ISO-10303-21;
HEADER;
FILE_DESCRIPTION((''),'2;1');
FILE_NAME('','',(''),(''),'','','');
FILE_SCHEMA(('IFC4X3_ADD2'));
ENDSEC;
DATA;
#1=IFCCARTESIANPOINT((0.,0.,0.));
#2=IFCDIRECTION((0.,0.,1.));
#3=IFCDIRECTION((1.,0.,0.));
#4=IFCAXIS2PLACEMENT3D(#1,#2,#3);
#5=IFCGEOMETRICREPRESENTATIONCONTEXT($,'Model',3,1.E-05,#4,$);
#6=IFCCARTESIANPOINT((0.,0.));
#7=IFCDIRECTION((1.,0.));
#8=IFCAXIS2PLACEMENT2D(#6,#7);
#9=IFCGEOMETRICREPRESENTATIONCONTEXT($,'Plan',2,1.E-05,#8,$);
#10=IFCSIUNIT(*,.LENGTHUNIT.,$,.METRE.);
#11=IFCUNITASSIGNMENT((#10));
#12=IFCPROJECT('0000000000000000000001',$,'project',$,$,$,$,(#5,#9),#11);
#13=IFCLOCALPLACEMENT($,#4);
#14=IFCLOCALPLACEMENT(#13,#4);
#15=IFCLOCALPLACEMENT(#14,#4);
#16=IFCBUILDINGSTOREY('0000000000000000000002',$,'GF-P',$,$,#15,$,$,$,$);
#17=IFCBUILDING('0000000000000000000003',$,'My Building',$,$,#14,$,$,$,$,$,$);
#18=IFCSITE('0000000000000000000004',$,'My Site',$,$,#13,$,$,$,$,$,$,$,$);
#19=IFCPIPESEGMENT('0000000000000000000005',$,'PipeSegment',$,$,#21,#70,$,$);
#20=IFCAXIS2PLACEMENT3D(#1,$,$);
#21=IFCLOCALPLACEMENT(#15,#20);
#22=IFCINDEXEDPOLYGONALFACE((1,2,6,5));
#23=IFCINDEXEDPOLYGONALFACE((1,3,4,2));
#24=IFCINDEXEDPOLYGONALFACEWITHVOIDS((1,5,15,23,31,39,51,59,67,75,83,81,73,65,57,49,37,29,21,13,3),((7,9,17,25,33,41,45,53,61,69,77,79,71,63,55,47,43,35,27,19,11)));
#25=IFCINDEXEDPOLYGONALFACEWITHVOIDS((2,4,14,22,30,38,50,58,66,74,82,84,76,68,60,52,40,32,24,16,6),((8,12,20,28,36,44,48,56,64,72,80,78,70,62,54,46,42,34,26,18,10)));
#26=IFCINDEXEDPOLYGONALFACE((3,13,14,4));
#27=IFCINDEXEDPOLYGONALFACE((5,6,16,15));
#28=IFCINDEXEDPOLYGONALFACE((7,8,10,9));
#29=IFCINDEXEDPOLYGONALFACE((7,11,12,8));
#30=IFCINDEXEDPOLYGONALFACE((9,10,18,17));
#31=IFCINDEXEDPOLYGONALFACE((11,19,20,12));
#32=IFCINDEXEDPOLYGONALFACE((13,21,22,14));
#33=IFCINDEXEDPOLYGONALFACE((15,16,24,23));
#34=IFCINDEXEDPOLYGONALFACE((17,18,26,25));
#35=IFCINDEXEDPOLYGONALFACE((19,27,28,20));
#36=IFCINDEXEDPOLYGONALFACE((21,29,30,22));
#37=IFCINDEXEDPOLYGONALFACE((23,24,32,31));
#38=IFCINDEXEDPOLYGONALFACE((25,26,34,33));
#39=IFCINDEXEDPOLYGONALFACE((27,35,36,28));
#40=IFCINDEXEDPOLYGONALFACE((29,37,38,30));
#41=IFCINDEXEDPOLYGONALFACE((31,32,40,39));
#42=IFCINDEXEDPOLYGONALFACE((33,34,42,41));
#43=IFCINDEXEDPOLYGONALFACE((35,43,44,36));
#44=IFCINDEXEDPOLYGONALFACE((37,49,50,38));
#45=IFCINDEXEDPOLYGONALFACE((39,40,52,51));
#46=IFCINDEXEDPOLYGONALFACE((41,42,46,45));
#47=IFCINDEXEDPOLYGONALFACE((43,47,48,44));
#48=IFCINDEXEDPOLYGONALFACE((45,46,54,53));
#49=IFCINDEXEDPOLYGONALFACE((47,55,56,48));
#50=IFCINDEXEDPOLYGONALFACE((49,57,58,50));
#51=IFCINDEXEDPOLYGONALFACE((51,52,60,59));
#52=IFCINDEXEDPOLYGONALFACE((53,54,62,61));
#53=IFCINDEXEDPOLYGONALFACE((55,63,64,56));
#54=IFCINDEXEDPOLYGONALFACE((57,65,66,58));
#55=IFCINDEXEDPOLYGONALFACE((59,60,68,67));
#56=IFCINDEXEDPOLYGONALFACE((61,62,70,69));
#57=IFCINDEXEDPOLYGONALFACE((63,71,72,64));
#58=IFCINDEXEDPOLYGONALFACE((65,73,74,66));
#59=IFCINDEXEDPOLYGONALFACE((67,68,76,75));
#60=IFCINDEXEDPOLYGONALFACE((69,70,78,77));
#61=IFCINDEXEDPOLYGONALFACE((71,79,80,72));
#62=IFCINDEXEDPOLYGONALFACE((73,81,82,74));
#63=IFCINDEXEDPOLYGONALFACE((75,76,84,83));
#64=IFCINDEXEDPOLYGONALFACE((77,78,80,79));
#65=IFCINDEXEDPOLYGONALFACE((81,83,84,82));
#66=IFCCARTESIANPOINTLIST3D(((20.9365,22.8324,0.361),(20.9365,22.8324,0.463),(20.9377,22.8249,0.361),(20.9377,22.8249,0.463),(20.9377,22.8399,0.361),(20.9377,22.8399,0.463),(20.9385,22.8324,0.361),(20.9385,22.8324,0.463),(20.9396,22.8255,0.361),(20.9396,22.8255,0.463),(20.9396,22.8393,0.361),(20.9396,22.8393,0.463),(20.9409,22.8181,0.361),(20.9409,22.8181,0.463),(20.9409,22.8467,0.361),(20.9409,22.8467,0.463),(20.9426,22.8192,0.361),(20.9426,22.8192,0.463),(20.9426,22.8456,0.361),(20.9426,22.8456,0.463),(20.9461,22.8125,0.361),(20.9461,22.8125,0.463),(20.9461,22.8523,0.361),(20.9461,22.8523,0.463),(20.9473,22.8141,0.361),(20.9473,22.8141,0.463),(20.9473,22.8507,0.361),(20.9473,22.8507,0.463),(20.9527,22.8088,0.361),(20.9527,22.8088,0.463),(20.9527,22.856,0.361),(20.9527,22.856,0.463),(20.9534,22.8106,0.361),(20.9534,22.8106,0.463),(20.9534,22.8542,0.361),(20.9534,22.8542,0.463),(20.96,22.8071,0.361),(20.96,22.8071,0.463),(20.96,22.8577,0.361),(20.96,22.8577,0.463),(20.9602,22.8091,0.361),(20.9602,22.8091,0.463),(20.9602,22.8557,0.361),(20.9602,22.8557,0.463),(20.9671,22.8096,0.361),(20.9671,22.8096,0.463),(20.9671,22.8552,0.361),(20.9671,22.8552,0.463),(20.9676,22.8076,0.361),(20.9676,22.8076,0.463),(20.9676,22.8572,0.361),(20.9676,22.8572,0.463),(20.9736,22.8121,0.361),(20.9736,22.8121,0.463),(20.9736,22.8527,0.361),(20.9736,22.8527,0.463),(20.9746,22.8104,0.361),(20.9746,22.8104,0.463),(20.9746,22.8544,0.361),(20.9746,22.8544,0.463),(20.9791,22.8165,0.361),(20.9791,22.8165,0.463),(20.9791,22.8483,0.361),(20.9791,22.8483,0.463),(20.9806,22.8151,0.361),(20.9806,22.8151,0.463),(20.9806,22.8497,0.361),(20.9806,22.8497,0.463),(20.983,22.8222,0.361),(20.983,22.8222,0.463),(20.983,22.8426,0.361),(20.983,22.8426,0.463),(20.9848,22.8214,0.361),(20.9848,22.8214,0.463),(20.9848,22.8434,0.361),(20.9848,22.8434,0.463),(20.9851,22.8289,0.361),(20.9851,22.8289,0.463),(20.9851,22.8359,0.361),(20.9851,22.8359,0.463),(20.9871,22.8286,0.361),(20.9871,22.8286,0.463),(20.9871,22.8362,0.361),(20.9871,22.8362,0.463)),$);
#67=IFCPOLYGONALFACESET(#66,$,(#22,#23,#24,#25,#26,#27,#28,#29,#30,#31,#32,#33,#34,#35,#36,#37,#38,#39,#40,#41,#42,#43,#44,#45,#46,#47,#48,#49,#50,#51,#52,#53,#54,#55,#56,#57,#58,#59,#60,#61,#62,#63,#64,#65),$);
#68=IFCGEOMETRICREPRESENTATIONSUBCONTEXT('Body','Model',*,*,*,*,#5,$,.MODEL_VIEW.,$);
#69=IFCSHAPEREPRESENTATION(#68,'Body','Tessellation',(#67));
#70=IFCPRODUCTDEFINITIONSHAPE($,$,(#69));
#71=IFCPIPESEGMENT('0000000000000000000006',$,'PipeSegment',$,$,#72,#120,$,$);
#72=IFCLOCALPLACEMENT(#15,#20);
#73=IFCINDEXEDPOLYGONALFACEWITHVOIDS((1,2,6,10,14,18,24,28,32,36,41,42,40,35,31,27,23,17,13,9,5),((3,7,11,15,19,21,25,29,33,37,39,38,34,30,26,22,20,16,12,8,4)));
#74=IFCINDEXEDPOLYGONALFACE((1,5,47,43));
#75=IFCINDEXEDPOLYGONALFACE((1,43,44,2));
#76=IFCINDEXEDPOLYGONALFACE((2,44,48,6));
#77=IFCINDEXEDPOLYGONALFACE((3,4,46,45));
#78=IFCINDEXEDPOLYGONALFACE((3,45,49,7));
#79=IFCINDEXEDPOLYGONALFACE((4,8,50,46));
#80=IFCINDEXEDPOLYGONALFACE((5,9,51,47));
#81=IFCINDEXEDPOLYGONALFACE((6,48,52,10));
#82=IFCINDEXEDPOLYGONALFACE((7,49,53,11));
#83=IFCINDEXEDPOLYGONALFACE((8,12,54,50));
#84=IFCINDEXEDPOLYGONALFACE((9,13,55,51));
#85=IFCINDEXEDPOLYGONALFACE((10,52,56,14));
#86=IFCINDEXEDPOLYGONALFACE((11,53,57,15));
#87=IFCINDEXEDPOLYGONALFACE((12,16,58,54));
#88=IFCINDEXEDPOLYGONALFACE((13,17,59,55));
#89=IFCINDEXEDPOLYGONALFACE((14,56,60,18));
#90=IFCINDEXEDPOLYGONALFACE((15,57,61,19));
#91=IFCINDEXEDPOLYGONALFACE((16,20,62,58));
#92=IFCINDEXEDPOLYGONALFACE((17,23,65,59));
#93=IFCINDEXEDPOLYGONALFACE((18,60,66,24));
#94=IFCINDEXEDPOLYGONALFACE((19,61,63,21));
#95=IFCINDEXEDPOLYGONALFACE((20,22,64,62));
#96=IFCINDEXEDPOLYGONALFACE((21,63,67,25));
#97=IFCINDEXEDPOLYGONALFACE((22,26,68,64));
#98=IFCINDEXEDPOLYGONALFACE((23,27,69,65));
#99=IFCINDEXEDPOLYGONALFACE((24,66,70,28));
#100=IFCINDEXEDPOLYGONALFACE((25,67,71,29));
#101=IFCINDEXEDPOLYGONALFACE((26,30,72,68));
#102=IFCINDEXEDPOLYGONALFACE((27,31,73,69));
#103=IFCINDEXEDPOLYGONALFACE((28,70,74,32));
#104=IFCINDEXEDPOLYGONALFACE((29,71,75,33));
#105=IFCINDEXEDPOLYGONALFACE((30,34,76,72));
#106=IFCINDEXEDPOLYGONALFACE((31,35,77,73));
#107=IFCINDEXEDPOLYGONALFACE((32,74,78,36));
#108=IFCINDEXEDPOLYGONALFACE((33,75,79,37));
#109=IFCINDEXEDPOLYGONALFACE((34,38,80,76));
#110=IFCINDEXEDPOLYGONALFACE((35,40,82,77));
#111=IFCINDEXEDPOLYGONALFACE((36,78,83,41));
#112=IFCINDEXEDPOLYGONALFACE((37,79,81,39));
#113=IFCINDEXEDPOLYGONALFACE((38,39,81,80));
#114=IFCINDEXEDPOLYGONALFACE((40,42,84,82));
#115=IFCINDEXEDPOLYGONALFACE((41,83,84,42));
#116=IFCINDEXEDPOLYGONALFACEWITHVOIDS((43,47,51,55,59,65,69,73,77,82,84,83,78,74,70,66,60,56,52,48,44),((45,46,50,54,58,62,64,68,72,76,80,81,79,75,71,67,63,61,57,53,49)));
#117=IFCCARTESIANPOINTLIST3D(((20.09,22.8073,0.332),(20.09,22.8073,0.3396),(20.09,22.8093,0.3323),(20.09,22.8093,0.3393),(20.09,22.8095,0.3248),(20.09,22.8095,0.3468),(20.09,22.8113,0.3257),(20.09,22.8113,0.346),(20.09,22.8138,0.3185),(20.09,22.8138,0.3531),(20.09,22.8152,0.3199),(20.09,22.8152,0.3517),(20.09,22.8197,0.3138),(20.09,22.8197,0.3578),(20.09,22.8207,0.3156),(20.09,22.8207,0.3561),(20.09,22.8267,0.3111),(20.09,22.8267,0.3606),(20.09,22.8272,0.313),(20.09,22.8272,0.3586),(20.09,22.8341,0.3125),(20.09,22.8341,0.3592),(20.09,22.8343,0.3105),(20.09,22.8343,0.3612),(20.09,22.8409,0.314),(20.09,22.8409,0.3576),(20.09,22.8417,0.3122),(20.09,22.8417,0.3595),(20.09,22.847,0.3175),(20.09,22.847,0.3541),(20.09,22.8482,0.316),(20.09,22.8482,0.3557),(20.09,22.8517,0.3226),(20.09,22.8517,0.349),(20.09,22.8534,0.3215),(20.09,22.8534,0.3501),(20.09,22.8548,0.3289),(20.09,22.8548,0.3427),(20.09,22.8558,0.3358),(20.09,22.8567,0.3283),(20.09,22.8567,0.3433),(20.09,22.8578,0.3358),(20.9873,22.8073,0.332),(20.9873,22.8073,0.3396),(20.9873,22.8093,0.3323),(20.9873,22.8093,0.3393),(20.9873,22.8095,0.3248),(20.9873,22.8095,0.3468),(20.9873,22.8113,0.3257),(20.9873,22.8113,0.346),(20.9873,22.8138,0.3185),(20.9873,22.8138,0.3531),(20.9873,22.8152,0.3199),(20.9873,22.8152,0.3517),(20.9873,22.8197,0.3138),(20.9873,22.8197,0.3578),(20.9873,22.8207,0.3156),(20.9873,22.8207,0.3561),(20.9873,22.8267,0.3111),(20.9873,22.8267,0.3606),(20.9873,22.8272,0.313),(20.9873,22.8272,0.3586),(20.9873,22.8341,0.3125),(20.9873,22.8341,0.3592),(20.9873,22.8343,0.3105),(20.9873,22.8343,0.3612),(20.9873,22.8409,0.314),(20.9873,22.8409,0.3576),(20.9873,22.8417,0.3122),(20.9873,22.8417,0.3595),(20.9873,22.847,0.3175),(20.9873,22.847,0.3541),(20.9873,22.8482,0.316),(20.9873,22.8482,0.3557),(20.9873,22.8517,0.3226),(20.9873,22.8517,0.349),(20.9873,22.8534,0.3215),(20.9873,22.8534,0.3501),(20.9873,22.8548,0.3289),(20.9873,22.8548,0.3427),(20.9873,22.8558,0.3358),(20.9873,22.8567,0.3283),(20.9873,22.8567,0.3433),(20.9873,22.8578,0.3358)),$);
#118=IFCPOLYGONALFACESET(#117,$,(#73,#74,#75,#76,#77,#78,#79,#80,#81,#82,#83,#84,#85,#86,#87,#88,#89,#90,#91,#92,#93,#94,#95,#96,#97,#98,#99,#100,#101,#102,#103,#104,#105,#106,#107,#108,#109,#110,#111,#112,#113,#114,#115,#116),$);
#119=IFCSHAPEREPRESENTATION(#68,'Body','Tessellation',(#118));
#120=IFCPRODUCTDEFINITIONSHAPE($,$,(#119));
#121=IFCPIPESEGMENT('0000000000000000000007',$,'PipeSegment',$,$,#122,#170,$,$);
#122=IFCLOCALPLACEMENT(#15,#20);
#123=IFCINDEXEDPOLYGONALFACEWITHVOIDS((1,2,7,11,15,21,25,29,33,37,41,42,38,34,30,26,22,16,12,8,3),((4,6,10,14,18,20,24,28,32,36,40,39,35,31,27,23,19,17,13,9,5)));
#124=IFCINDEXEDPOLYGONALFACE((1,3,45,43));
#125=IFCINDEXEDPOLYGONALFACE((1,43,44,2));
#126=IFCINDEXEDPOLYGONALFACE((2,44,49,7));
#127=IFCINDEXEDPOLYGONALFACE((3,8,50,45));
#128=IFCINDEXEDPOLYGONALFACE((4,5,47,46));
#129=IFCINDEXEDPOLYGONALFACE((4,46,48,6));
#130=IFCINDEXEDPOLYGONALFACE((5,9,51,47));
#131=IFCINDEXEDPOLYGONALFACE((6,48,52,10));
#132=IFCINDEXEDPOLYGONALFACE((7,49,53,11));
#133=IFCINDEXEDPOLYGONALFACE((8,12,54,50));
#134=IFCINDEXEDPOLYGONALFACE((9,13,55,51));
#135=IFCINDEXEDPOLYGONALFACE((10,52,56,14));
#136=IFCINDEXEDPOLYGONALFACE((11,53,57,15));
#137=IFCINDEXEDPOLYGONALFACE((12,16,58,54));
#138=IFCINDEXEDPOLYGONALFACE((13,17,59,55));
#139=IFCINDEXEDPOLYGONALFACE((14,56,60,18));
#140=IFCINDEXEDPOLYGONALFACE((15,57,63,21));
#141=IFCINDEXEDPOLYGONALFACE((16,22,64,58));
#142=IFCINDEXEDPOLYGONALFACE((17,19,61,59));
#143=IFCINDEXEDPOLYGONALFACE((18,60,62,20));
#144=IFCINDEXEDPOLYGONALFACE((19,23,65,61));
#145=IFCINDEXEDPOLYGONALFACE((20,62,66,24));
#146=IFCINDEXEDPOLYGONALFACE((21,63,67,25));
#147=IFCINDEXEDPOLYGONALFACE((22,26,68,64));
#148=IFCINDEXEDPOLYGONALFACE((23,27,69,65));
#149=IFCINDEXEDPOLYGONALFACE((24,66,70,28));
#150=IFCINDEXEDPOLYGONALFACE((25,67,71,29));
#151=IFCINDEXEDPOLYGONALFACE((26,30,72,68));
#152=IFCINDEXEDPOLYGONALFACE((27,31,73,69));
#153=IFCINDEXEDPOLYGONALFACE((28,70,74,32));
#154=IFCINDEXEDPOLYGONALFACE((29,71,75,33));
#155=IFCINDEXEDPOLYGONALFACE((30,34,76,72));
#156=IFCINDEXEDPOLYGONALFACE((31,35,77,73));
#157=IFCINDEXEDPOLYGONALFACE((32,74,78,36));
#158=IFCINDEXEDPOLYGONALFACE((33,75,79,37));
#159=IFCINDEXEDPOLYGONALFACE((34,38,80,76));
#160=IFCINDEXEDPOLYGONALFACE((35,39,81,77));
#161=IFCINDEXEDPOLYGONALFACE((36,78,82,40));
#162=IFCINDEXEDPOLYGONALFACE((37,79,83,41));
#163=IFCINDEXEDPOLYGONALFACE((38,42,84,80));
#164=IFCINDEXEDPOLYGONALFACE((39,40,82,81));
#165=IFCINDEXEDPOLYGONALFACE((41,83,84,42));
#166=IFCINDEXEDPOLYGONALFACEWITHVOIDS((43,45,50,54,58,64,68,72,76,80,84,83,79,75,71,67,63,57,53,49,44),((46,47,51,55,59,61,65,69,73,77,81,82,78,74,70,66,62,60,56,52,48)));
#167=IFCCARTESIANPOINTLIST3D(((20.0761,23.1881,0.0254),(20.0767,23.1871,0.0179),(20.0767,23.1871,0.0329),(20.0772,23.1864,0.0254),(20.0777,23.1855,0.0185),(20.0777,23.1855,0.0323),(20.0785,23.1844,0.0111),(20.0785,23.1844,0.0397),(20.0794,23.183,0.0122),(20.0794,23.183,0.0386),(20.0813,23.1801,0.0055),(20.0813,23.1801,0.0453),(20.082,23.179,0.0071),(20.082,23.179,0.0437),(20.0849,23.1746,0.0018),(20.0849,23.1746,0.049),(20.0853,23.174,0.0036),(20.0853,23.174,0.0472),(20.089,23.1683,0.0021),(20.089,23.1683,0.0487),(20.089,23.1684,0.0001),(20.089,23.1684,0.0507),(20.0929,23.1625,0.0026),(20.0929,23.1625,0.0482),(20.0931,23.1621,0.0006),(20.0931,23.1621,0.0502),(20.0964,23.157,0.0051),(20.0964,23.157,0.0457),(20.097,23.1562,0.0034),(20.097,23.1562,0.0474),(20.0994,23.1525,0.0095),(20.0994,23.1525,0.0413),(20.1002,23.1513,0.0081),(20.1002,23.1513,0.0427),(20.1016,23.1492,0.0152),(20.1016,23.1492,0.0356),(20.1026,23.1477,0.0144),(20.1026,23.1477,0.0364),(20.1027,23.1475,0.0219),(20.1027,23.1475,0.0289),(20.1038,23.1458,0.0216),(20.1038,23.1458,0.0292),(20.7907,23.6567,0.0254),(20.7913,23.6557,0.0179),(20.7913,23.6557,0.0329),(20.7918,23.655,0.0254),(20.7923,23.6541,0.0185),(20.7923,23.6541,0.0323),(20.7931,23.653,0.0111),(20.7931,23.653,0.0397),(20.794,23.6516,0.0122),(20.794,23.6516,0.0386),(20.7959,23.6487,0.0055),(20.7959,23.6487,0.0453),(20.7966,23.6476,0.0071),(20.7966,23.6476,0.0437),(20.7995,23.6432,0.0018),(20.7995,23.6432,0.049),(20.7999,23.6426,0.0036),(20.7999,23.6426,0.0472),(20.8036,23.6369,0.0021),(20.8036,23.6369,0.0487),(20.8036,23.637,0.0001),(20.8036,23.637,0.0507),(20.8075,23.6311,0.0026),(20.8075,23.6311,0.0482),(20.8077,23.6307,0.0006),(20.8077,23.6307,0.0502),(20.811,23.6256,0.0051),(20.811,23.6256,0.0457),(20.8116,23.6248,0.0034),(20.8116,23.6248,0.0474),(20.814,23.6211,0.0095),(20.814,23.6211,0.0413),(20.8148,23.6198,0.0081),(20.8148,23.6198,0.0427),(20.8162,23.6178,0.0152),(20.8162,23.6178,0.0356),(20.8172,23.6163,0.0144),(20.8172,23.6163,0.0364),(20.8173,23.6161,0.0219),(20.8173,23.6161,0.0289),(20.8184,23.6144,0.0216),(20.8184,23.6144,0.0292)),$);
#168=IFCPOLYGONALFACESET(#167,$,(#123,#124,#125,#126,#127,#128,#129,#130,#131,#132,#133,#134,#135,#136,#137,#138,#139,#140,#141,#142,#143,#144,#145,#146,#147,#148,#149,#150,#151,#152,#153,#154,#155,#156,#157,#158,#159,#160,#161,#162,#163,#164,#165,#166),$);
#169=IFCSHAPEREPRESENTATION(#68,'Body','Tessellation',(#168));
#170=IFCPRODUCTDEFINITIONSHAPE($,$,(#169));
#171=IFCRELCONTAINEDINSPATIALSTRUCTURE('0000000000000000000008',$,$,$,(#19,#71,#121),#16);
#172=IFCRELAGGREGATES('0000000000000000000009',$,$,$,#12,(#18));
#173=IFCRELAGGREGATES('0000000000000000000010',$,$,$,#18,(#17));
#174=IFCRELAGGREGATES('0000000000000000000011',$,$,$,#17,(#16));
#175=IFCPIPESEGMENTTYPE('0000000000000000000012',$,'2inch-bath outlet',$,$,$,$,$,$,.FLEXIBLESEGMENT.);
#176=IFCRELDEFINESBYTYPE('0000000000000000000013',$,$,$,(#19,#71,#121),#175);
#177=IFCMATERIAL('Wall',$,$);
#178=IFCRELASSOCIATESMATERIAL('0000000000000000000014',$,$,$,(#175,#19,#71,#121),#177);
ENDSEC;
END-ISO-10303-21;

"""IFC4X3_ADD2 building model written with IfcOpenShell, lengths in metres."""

from ifc_helpers import new_model, si_unit, frame, origin_with_axes, origin_2d_with_axis, place, context, subcontext, project, spatial, hollow_circle, extrude, material, material_profile, profile_set, profile_usage, type_object, element, save


model = new_model("IFC4X3_ADD2")

# Units and contexts
model_context = context("Model", 3, precision=1e-05, world=origin_with_axes())
plan_context = context("Plan", 2, precision=1e-05, world=origin_2d_with_axis())
body_context = subcontext(model_context, "Body", "Model", "MODEL_VIEW")
ifc_project = project(units=[si_unit("LENGTHUNIT", "METRE")], contexts=[model_context, plan_context])

# Site, building, storey
site_placement = place(None, origin_with_axes())
site = spatial("IfcSite", under=ifc_project, at=site_placement, Name="My Site")
building_placement = place(site_placement, origin_with_axes())
building = spatial("IfcBuilding", under=site, at=building_placement, Name="My Building")
storey_placement = place(building_placement, origin_with_axes())
storey = spatial("IfcBuildingStorey", under=building, at=storey_placement, Name="GF-P")

# Pipe segments
ifc_material_1 = material(Name="Wall")
ifc_material_profile_1 = material_profile(ifc_material_1, hollow_circle(Radius=0.0254, WallThickness=0.002))
ifc_profile_set_1 = profile_set([ifc_material_profile_1], Name="graywater")
pipe_segment_type_1 = type_object("IfcPipeSegmentType", Name="2inch-bath outlet", PredefinedType="FLEXIBLESEGMENT", material=ifc_profile_set_1)
ifc_profile_usage_1 = profile_usage(ifc_profile_set_1)
pipe_segment_1_placement = place(storey_placement, frame((20.9619, 22.8324, 0.361), z_axis=(0.0, 0.0, 1.0), x_axis=(-1.0, 0.0, 0.0)))
element("IfcPipeSegment", 1, at=pipe_segment_1_placement, inside=storey, type_object=pipe_segment_type_1, material=ifc_profile_usage_1, Name="PipeSegment", context=body_context, shape_type="SweptSolid", body=[
    extrude(hollow_circle(Radius=0.0254, WallThickness=0.002), origin_with_axes(), (0.0, 0.0, 1.0), 0.1019),
])
ifc_profile_usage_2 = profile_usage(ifc_profile_set_1)
pipe_segment_2_placement = place(storey_placement, frame((20.09, 22.8324, 0.3358), z_axis=(1.0, 0.0, 0.0), x_axis=(0.0, 1.0, 0.0)))
element("IfcPipeSegment", 2, at=pipe_segment_2_placement, inside=storey, type_object=pipe_segment_type_1, material=ifc_profile_usage_2, Name="PipeSegment", context=body_context, shape_type="SweptSolid", body=[
    extrude(hollow_circle(Radius=0.0254, WallThickness=0.002), origin_with_axes(), (0.0, 0.0, 1.0), 0.8973),
])
ifc_profile_usage_3 = profile_usage(ifc_profile_set_1)
pipe_segment_3_placement = place(storey_placement, frame((20.09, 23.1668, 0.0254), z_axis=(0.836244, 0.548357, 0.0), x_axis=(-0.548357, 0.836244, 0.0)))
element("IfcPipeSegment", 3, at=pipe_segment_3_placement, inside=storey, type_object=pipe_segment_type_1, material=ifc_profile_usage_3, Name="PipeSegment", context=body_context, shape_type="SweptSolid", body=[
    extrude(hollow_circle(Radius=0.0254, WallThickness=0.002), origin_with_axes(), (0.0, 0.0, 1.0), 0.8545),
])

save(model, "model.ifc")
